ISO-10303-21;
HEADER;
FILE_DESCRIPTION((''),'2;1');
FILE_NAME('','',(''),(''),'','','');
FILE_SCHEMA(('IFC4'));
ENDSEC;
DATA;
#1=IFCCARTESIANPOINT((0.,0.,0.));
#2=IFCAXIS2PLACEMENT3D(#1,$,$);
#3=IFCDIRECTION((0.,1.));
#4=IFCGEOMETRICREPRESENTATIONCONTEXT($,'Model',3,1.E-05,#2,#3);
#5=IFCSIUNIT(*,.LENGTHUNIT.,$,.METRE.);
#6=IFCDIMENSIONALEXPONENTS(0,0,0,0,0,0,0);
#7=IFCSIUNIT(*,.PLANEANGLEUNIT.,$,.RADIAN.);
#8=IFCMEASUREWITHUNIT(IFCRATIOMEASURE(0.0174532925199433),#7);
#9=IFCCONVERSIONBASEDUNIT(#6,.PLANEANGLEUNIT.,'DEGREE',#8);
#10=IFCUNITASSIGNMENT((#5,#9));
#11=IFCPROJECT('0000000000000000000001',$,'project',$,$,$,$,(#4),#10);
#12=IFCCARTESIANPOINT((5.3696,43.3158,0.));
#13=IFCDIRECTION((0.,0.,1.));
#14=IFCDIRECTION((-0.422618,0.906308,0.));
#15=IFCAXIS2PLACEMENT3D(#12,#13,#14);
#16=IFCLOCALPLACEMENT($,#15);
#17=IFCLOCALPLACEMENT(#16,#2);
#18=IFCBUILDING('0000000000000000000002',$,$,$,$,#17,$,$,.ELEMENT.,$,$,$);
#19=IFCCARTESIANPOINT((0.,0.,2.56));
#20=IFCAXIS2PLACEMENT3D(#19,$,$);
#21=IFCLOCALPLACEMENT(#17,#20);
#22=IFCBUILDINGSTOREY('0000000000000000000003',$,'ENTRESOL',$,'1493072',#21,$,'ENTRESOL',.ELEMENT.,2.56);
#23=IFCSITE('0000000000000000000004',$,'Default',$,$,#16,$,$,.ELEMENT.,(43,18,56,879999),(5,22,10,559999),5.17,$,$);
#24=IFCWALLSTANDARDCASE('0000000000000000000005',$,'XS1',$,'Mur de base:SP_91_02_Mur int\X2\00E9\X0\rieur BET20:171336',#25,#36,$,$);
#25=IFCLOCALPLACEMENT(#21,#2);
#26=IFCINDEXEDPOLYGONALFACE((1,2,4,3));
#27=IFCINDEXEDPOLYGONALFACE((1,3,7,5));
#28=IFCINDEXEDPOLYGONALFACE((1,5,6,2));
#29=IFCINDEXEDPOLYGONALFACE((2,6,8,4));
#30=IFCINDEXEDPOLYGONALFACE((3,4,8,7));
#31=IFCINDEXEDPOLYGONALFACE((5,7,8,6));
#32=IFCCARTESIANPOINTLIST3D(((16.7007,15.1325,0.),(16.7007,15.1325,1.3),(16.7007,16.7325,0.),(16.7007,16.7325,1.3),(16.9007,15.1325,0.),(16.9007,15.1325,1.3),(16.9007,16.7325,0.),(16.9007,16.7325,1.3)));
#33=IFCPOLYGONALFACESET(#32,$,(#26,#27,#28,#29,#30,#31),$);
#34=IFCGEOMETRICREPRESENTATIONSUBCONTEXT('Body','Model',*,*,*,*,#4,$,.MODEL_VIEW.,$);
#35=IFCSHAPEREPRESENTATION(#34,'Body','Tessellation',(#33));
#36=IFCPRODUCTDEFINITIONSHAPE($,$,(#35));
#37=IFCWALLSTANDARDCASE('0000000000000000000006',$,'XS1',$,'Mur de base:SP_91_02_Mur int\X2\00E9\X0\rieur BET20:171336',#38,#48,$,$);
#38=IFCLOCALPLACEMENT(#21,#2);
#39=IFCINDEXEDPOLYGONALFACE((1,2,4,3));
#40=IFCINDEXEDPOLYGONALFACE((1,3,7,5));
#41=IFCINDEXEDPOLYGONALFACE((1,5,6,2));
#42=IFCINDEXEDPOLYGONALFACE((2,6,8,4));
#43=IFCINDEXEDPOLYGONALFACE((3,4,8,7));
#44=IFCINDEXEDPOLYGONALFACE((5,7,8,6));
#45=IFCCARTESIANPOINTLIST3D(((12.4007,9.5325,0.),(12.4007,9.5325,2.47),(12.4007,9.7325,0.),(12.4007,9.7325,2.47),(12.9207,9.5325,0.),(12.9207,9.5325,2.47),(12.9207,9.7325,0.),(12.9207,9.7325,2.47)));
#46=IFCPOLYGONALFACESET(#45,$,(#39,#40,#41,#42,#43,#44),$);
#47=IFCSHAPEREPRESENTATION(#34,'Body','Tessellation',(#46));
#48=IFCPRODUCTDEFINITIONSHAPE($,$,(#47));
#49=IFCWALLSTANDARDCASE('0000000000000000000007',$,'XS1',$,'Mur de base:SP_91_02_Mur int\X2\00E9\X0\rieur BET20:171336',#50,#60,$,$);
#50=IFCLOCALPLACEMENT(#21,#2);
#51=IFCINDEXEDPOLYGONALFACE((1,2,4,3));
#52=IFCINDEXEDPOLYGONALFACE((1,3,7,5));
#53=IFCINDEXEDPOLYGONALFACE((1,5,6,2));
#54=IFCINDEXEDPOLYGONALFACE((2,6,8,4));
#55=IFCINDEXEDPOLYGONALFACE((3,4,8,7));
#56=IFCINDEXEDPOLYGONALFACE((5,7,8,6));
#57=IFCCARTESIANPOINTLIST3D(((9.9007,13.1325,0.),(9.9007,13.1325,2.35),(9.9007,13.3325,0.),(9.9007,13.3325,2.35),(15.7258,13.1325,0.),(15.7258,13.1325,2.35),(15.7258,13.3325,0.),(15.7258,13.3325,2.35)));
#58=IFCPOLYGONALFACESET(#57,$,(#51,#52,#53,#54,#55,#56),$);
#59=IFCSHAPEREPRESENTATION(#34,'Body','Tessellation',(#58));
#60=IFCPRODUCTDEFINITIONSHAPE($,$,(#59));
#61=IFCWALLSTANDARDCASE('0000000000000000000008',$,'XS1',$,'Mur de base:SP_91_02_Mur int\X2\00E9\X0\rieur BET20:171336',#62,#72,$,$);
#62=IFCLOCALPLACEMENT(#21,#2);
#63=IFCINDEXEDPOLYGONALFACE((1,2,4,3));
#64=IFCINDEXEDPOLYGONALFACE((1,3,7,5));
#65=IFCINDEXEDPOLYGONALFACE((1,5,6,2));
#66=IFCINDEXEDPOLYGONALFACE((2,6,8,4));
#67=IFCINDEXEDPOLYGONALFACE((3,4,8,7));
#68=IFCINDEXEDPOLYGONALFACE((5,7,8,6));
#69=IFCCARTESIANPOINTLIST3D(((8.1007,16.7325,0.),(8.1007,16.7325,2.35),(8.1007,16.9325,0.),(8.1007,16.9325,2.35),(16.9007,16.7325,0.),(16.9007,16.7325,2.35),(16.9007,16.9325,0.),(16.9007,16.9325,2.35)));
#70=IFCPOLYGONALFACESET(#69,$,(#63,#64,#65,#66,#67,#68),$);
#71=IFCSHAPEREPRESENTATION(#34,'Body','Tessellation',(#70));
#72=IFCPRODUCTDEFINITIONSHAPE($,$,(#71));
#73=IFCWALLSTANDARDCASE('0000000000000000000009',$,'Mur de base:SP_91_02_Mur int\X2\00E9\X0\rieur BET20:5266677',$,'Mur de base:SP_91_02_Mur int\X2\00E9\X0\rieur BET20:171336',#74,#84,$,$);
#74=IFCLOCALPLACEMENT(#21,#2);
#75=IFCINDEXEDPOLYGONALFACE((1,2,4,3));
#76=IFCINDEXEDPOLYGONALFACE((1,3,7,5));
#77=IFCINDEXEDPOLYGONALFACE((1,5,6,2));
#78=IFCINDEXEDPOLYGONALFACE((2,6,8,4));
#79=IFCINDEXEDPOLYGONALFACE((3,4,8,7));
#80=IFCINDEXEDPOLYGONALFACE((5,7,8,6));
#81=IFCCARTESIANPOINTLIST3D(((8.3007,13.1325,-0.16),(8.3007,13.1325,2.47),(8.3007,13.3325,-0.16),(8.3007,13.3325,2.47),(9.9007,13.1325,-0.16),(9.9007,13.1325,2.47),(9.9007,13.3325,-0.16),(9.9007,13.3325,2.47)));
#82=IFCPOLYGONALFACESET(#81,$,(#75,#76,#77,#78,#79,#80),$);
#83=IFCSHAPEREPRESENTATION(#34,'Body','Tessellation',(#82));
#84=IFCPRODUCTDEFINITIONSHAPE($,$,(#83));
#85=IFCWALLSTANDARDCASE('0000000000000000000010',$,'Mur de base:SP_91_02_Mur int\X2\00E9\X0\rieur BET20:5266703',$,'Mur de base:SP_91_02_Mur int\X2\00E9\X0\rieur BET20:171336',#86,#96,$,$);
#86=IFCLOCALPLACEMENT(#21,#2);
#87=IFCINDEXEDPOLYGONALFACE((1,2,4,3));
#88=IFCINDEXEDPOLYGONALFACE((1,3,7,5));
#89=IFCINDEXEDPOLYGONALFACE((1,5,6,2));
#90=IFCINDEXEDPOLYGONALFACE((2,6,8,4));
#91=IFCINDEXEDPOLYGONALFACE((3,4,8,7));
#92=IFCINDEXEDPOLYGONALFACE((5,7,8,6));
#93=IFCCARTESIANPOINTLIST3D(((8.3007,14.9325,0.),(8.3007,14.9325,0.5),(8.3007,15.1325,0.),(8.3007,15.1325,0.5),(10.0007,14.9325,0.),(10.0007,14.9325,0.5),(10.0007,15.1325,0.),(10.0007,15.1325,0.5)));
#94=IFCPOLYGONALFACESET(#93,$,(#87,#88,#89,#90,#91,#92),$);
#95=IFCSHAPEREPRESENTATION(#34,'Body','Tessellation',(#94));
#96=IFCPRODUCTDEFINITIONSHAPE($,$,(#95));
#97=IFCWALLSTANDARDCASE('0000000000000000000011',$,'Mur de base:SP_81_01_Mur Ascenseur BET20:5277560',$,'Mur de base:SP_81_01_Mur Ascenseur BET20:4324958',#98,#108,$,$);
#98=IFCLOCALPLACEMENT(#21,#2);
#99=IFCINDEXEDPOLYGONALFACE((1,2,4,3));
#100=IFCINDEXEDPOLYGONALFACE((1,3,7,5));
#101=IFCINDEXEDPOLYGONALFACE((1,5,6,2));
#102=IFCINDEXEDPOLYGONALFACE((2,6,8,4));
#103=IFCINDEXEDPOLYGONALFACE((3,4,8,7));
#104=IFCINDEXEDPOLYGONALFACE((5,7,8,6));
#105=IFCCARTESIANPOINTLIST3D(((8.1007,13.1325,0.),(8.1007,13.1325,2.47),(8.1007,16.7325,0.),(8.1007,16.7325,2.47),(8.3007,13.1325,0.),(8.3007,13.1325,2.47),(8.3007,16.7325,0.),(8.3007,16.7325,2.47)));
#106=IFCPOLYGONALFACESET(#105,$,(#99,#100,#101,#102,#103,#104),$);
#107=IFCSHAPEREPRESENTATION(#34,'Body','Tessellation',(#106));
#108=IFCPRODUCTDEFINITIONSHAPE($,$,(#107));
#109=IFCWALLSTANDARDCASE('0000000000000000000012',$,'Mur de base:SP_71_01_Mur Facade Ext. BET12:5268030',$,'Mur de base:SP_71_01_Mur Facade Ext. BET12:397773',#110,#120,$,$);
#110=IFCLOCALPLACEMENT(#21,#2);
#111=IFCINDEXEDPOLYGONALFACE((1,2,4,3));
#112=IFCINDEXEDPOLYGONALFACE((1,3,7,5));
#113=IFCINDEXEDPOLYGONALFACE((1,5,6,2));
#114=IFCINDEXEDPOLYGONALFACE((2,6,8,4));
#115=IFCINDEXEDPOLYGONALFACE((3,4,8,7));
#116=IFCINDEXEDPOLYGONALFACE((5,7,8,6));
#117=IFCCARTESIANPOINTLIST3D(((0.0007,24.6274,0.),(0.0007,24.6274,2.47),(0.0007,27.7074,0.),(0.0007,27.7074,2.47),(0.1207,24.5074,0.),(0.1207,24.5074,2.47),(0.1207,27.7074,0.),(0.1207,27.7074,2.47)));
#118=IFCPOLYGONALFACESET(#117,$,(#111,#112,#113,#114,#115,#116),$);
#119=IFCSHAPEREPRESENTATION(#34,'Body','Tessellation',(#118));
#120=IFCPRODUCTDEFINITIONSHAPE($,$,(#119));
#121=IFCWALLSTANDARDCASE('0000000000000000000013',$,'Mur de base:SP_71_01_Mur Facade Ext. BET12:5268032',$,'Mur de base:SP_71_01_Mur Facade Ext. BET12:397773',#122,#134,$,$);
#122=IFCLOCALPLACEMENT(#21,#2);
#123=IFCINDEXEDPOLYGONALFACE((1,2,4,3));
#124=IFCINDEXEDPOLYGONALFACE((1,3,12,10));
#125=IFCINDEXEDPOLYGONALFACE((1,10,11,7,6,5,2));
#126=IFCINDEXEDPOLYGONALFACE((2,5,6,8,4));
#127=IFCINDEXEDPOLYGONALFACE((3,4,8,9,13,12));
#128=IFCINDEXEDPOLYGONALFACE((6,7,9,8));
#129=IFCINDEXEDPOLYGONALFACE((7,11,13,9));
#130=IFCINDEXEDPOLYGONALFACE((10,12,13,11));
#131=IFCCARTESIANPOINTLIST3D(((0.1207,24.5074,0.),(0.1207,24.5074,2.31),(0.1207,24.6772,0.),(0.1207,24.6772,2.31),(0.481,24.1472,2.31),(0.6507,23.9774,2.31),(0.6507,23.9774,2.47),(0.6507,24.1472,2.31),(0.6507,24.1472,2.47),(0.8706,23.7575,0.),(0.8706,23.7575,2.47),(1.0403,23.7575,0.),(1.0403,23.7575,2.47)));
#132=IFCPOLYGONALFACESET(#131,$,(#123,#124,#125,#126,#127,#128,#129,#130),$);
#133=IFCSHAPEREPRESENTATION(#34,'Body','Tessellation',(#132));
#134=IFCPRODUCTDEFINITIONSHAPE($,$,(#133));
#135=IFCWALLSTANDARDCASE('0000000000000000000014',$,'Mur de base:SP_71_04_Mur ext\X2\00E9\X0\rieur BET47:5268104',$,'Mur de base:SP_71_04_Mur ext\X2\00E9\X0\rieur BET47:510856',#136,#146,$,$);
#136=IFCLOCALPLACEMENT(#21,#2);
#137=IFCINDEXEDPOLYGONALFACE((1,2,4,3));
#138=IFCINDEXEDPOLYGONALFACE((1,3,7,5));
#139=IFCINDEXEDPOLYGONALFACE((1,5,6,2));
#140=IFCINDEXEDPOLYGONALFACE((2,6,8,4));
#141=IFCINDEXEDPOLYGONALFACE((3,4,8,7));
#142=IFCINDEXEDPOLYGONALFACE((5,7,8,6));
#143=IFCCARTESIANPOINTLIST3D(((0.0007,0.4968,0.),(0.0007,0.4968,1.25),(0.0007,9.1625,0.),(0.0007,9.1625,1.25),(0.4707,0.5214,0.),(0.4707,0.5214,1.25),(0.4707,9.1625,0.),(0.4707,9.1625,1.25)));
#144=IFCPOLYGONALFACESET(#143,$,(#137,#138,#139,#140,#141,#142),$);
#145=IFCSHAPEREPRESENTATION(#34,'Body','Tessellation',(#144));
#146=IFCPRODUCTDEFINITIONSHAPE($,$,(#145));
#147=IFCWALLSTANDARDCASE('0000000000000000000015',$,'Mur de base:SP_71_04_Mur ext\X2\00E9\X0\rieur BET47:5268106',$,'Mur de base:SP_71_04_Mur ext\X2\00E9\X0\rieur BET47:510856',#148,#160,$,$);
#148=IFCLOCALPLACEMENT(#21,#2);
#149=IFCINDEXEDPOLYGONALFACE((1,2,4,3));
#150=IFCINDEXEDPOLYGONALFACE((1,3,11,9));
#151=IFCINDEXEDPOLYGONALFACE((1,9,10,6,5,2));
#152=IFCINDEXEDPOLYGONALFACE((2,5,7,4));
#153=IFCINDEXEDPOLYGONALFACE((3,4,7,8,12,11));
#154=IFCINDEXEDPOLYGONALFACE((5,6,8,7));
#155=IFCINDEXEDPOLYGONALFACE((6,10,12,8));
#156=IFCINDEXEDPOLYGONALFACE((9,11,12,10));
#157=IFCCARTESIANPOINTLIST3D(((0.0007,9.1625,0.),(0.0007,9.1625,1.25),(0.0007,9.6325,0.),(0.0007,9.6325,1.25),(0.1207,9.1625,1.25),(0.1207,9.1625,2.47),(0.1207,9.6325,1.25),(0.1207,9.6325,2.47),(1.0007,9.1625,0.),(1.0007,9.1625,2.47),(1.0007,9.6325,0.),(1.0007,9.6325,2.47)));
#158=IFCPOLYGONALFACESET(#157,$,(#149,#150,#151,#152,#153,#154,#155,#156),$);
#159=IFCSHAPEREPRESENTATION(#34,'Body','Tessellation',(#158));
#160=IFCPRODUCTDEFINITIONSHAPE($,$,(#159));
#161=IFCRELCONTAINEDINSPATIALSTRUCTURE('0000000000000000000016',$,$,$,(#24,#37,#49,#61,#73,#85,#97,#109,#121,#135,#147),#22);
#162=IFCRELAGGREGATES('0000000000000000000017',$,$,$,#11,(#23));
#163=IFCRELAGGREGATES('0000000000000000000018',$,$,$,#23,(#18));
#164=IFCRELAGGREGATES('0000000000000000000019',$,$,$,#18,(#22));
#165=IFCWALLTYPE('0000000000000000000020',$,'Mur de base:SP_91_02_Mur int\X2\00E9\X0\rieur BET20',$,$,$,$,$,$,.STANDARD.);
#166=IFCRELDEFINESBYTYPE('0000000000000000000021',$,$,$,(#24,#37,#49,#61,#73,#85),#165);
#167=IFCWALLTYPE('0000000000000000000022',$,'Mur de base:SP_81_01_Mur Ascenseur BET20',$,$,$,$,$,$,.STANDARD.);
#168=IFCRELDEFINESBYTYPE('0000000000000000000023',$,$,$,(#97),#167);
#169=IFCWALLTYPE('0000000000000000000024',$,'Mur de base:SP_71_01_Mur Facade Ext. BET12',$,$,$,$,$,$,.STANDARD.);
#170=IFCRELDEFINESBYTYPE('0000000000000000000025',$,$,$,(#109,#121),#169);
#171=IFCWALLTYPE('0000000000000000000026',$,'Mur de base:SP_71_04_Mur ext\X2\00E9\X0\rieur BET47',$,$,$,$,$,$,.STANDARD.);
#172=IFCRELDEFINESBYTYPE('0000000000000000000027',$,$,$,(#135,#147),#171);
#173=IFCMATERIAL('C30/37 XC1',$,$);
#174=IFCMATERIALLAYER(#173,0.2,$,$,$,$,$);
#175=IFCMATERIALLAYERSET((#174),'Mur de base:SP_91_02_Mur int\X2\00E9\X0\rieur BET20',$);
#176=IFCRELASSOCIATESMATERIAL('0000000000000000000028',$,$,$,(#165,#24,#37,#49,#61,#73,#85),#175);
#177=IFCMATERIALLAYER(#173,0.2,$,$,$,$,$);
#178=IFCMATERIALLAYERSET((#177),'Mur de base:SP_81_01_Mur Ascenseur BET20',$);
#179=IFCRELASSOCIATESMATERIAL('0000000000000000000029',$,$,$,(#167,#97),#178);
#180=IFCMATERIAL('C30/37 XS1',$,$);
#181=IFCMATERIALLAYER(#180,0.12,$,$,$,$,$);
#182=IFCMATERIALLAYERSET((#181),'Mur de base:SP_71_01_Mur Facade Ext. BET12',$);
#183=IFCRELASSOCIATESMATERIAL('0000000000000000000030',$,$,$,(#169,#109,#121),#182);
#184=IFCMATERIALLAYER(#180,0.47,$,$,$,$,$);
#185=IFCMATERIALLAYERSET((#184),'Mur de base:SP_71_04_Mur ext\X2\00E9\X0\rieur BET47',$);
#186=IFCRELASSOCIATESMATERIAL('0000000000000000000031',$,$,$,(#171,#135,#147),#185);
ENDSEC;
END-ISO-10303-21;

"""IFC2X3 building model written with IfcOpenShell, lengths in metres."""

from ifc_helpers import new_model, entity, si_unit, converted_unit, direction, frame, frame_2d, origin, place, context, subcontext, project, spatial, polyline, rectangle, outline, extrude, clip, halfspace, bounded_halfspace, material, layer, layer_set, layer_usage, type_object, element, save


model = new_model("IFC2X3")

# Units and contexts
model_context = context("Model", 3, precision=1e-05, world=origin(), true_north=direction((0.0, 1.0)))
body_context = subcontext(model_context, "Body", "Model", "MODEL_VIEW")
ifc_project = project(units=[si_unit("LENGTHUNIT", "METRE"), converted_unit("PLANEANGLEUNIT", "DEGREE", entity("IfcRatioMeasure", 0.0174532925199433), si_unit("PLANEANGLEUNIT", "RADIAN"), dimensions=[0, 0, 0, 0, 0, 0, 0])], contexts=[model_context])

# Site, building, storey
site_placement = place(None, frame((5.3696, 43.3158, 0.0), z_axis=(0.0, 0.0, 1.0), x_axis=(-0.422618, 0.906308, 0.0)))
site = spatial("IfcSite", under=ifc_project, at=site_placement, Name="Default", CompositionType="ELEMENT", RefLatitude=(43, 18, 56, 879999), RefLongitude=(5, 22, 10, 559999), RefElevation=5.17)
building_placement = place(site_placement, origin())
building = spatial("IfcBuilding", under=site, at=building_placement, CompositionType="ELEMENT")
storey_placement = place(building_placement, frame((0.0, 0.0, 2.56)))
storey = spatial("IfcBuildingStorey", under=building, at=storey_placement, Name="ENTRESOL", ObjectType="1493072", LongName="ENTRESOL", CompositionType="ELEMENT", Elevation=2.56)

# Walls
ifc_material_1 = material(Name="C30/37 XC1")
ifc_layer_1 = layer(ifc_material_1, 0.2)
ifc_layer_set_1 = layer_set([ifc_layer_1], Name="Mur de base:SP_91_02_Mur intérieur BET20")
wall_type_1 = type_object("IfcWallType", Name="Mur de base:SP_91_02_Mur intérieur BET20", PredefinedType="STANDARD", material=ifc_layer_set_1)
ifc_layer_usage_1 = layer_usage(ifc_layer_set_1, "AXIS2", "NEGATIVE", 0.1)
wall_1_placement = place(storey_placement, frame((16.8007, 16.7325, 0.0), z_axis=(0.0, 0.0, 1.0), x_axis=(0.0, -1.0, 0.0)))
element("IfcWallStandardCase", 1, at=wall_1_placement, inside=storey, type_object=wall_type_1, material=ifc_layer_usage_1, Name="XS1", ObjectType="Mur de base:SP_91_02_Mur intérieur BET20:171336", context=body_context, shape_type="Clipping", body=[
    clip(extrude(rectangle(XDim=1.6, YDim=0.2, at=frame_2d((0.8, 0.0), x_axis=(-1.0, 0.0))), origin(), (0.0, 0.0, 1.0), 1.3), halfspace(frame((0.0, 0.0, -2.56)), True)),
])
ifc_layer_usage_2 = layer_usage(ifc_layer_set_1, "AXIS2", "NEGATIVE", 0.1)
wall_2_placement = place(storey_placement, frame((12.9207, 9.6325, 0.0), z_axis=(0.0, 0.0, 1.0), x_axis=(-1.0, 0.0, 0.0)))
element("IfcWallStandardCase", 2, at=wall_2_placement, inside=storey, type_object=wall_type_1, material=ifc_layer_usage_2, Name="XS1", ObjectType="Mur de base:SP_91_02_Mur intérieur BET20:171336", context=body_context, shape_type="Clipping", body=[
    clip(extrude(rectangle(XDim=0.52, YDim=0.2, at=frame_2d((0.26, 0.0), x_axis=(-1.0, 0.0))), origin(), (0.0, 0.0, 1.0), 2.47), halfspace(frame((0.0, 0.0, -2.56)), True)),
])
ifc_layer_usage_3 = layer_usage(ifc_layer_set_1, "AXIS2", "NEGATIVE", 0.1)
wall_3_placement = place(storey_placement, frame((9.9007, 13.2325, 0.0)))
element("IfcWallStandardCase", 3, at=wall_3_placement, inside=storey, type_object=wall_type_1, material=ifc_layer_usage_3, Name="XS1", ObjectType="Mur de base:SP_91_02_Mur intérieur BET20:171336", context=body_context, shape_type="Clipping", body=[
    clip(extrude(rectangle(XDim=5.8251, YDim=0.2, at=frame_2d((2.9126, 0.0), x_axis=(-1.0, 0.0))), origin(), (0.0, 0.0, 1.0), 2.35), halfspace(frame((0.0, 0.0, -2.56)), True)),
])
ifc_layer_usage_4 = layer_usage(ifc_layer_set_1, "AXIS2", "NEGATIVE", 0.1)
wall_4_placement = place(storey_placement, frame((8.1007, 16.8325, 0.0)))
element("IfcWallStandardCase", 4, at=wall_4_placement, inside=storey, type_object=wall_type_1, material=ifc_layer_usage_4, Name="XS1", ObjectType="Mur de base:SP_91_02_Mur intérieur BET20:171336", context=body_context, shape_type="Clipping", body=[
    clip(extrude(rectangle(XDim=8.8, YDim=0.2, at=frame_2d((4.4, 0.0), x_axis=(-1.0, 0.0))), origin(), (0.0, 0.0, 1.0), 2.35), halfspace(frame((0.0, 0.0, -2.56)), True)),
])
ifc_layer_usage_5 = layer_usage(ifc_layer_set_1, "AXIS2", "NEGATIVE", 0.1)
wall_5_placement = place(storey_placement, frame((10.0007, 13.2325, -0.16), z_axis=(0.0, 0.0, 1.0), x_axis=(-1.0, 0.0, 0.0)))
element("IfcWallStandardCase", 5, at=wall_5_placement, inside=storey, type_object=wall_type_1, material=ifc_layer_usage_5, Name="Mur de base:SP_91_02_Mur intérieur BET20:5266677", ObjectType="Mur de base:SP_91_02_Mur intérieur BET20:171336", context=body_context, shape_type="SweptSolid", body=[
    extrude(rectangle(XDim=1.6, YDim=0.2, at=frame_2d((0.9, 0.0), x_axis=(-1.0, 0.0))), origin(), (0.0, 0.0, 1.0), 2.63),
])
ifc_layer_usage_6 = layer_usage(ifc_layer_set_1, "AXIS2", "NEGATIVE", 0.1)
wall_6_placement = place(storey_placement, frame((10.0007, 15.0325, 0.0), z_axis=(0.0, 0.0, 1.0), x_axis=(-1.0, 0.0, 0.0)))
element("IfcWallStandardCase", 6, at=wall_6_placement, inside=storey, type_object=wall_type_1, material=ifc_layer_usage_6, Name="Mur de base:SP_91_02_Mur intérieur BET20:5266703", ObjectType="Mur de base:SP_91_02_Mur intérieur BET20:171336", context=body_context, shape_type="Clipping", body=[
    clip(extrude(rectangle(XDim=1.7, YDim=0.2, at=frame_2d((0.85, 0.0), x_axis=(-1.0, 0.0))), origin(), (0.0, 0.0, 1.0), 0.5), halfspace(frame((0.0, 0.0, -2.56)), True)),
])

# Shared definitions
ifc_material_2 = material(Name="C30/37 XS1")

# Wall
ifc_layer_2 = layer(ifc_material_1, 0.2)
ifc_layer_set_2 = layer_set([ifc_layer_2], Name="Mur de base:SP_81_01_Mur Ascenseur BET20")
ifc_layer_usage_7 = layer_usage(ifc_layer_set_2, "AXIS2", "NEGATIVE", 0.1)
wall_type_2 = type_object("IfcWallType", Name="Mur de base:SP_81_01_Mur Ascenseur BET20", PredefinedType="STANDARD", material=ifc_layer_set_2)
wall_7_placement = place(storey_placement, frame((8.2007, 16.7325, 0.0), z_axis=(0.0, 0.0, 1.0), x_axis=(0.0, -1.0, 0.0)))
element("IfcWallStandardCase", 7, at=wall_7_placement, inside=storey, type_object=wall_type_2, material=ifc_layer_usage_7, Name="Mur de base:SP_81_01_Mur Ascenseur BET20:5277560", ObjectType="Mur de base:SP_81_01_Mur Ascenseur BET20:4324958", context=body_context, shape_type="Clipping", body=[
    clip(extrude(rectangle(XDim=3.6, YDim=0.2, at=frame_2d((1.8, 0.0), x_axis=(-1.0, 0.0))), origin(), (0.0, 0.0, 1.0), 2.47), halfspace(frame((0.0, 0.0, -2.56)), True)),
])

# Walls
ifc_layer_3 = layer(ifc_material_2, 0.12)
ifc_layer_set_3 = layer_set([ifc_layer_3], Name="Mur de base:SP_71_01_Mur Facade Ext. BET12")
ifc_layer_usage_8 = layer_usage(ifc_layer_set_3, "AXIS2", "NEGATIVE", 0.06)
wall_type_3 = type_object("IfcWallType", Name="Mur de base:SP_71_01_Mur Facade Ext. BET12", PredefinedType="STANDARD", material=ifc_layer_set_3)
wall_8_placement = place(storey_placement, frame((0.0607, 24.5074, 0.0), z_axis=(0.0, 0.0, 1.0), x_axis=(0.0, 1.0, 0.0)))
element("IfcWallStandardCase", 8, at=wall_8_placement, inside=storey, type_object=wall_type_3, material=ifc_layer_usage_8, Name="Mur de base:SP_71_01_Mur Facade Ext. BET12:5268030", ObjectType="Mur de base:SP_71_01_Mur Facade Ext. BET12:397773", context=body_context, shape_type="Clipping", body=[
    clip(extrude(outline(polyline([(3.2, -0.06), (3.2, 0.06), (0.12, 0.06), (0.0, -0.06), (0.1697, -0.06), (3.2, -0.06)])), origin(), (0.0, 0.0, 1.0), 2.47), halfspace(frame((0.0, 0.0, -2.56)), True)),
])
ifc_layer_usage_9 = layer_usage(ifc_layer_set_3, "AXIS2", "NEGATIVE", 0.06)
wall_9_placement = place(storey_placement, frame((0.9979, 23.7151, 0.0), z_axis=(0.0, 0.0, 1.0), x_axis=(-0.707107, 0.707107, 0.0)))
element("IfcWallStandardCase", 9, at=wall_9_placement, inside=storey, type_object=wall_type_3, material=ifc_layer_usage_9, Name="Mur de base:SP_71_01_Mur Facade Ext. BET12:5268032", ObjectType="Mur de base:SP_71_01_Mur Facade Ext. BET12:397773", context=body_context, shape_type="Clipping", body=[
    clip(clip(clip(extrude(outline(polyline([(1.3005, -0.06), (1.1805, 0.06), (0.12, 0.06), (0.0, -0.06), (0.056, -0.06), (1.3005, -0.06)])), origin(), (0.0, 0.0, 1.0), 2.47), bounded_halfspace(frame((0.431, 0.06, 2.31), z_axis=(0.0, 0.0, -1.0), x_axis=(-0.707107, 0.707107, 0.0)), True, frame((0.431, 0.06, 2.31), z_axis=(0.0, 0.0, -1.0), x_axis=(-0.707107, 0.707107, 0.0)), polyline([(0.0, 0.0), (-0.53, 0.53), (-0.6997, 0.53), (-0.1697, 0.0), (0.0, 0.0)]))), bounded_halfspace(frame((0.551, -0.06, 2.31), z_axis=(-0.707107, -0.707107, 0.0), x_axis=(0.0, 0.0, 1.0)), True, frame((0.551, -0.06, 2.31), z_axis=(-0.707107, -0.707107, 0.0), x_axis=(0.0, 0.0, 1.0)), polyline([(0.0, 0.0), (0.16, 0.0), (0.16, 0.1697), (0.0, 0.1697), (0.0, 0.0)]))), halfspace(frame((0.0, 0.0, -2.56)), True)),
])
ifc_layer_4 = layer(ifc_material_2, 0.47)
ifc_layer_set_4 = layer_set([ifc_layer_4], Name="Mur de base:SP_71_04_Mur extérieur BET47")
ifc_layer_usage_10 = layer_usage(ifc_layer_set_4, "AXIS2", "NEGATIVE", 0.235)
wall_type_4 = type_object("IfcWallType", Name="Mur de base:SP_71_04_Mur extérieur BET47", PredefinedType="STANDARD", material=ifc_layer_set_4)
wall_10_placement = place(storey_placement, frame((0.2357, 0.4968, 0.0), z_axis=(0.0, 0.0, 1.0), x_axis=(0.0, 1.0, 0.0)))
element("IfcWallStandardCase", 10, at=wall_10_placement, inside=storey, type_object=wall_type_4, material=ifc_layer_usage_10, Name="Mur de base:SP_71_04_Mur extérieur BET47:5268104", ObjectType="Mur de base:SP_71_04_Mur extérieur BET47:510856", context=body_context, shape_type="Clipping", body=[
    clip(extrude(outline(polyline([(8.6657, -0.235), (8.6657, 0.235), (0.0, 0.235), (0.0245, -0.235), (8.6657, -0.235)])), origin(), (0.0, 0.0, 1.0), 1.25), halfspace(frame((0.0, 0.0, -2.56)), True)),
])
ifc_layer_usage_11 = layer_usage(ifc_layer_set_4, "AXIS2", "NEGATIVE", 0.235)
wall_11_placement = place(storey_placement, frame((0.0007, 9.3975, 0.0)))
element("IfcWallStandardCase", 11, at=wall_11_placement, inside=storey, type_object=wall_type_4, material=ifc_layer_usage_11, Name="Mur de base:SP_71_04_Mur extérieur BET47:5268106", ObjectType="Mur de base:SP_71_04_Mur extérieur BET47:510856", context=body_context, shape_type="Clipping", body=[
    clip(clip(clip(extrude(rectangle(XDim=1.0, YDim=0.47, at=frame_2d((0.5, 0.0), x_axis=(-1.0, 0.0))), origin(), (0.0, 0.0, 1.0), 2.47), bounded_halfspace(frame((0.12, 0.235, 1.25), z_axis=(1.0, 0.0, 0.0), x_axis=(0.0, 1.0, 0.0)), True, frame((0.12, 0.235, 1.25), z_axis=(1.0, 0.0, 0.0), x_axis=(0.0, 1.0, 0.0)), polyline([(0.0, 0.0), (0.0, 1.22), (-0.47, 1.22), (-0.47, 0.0), (0.0, 0.0)]))), bounded_halfspace(frame((0.12, -0.235, 1.25), z_axis=(0.0, 0.0, -1.0), x_axis=(1.0, 0.0, 0.0)), True, frame((0.12, -0.235, 1.25), z_axis=(0.0, 0.0, -1.0), x_axis=(1.0, 0.0, 0.0)), polyline([(0.0, 0.0), (-0.12, 0.0), (-0.12, -0.47), (0.0, -0.47), (0.0, 0.0)]))), halfspace(frame((0.0, 0.0, -2.56)), True)),
])

save(model, "model.ifc")
